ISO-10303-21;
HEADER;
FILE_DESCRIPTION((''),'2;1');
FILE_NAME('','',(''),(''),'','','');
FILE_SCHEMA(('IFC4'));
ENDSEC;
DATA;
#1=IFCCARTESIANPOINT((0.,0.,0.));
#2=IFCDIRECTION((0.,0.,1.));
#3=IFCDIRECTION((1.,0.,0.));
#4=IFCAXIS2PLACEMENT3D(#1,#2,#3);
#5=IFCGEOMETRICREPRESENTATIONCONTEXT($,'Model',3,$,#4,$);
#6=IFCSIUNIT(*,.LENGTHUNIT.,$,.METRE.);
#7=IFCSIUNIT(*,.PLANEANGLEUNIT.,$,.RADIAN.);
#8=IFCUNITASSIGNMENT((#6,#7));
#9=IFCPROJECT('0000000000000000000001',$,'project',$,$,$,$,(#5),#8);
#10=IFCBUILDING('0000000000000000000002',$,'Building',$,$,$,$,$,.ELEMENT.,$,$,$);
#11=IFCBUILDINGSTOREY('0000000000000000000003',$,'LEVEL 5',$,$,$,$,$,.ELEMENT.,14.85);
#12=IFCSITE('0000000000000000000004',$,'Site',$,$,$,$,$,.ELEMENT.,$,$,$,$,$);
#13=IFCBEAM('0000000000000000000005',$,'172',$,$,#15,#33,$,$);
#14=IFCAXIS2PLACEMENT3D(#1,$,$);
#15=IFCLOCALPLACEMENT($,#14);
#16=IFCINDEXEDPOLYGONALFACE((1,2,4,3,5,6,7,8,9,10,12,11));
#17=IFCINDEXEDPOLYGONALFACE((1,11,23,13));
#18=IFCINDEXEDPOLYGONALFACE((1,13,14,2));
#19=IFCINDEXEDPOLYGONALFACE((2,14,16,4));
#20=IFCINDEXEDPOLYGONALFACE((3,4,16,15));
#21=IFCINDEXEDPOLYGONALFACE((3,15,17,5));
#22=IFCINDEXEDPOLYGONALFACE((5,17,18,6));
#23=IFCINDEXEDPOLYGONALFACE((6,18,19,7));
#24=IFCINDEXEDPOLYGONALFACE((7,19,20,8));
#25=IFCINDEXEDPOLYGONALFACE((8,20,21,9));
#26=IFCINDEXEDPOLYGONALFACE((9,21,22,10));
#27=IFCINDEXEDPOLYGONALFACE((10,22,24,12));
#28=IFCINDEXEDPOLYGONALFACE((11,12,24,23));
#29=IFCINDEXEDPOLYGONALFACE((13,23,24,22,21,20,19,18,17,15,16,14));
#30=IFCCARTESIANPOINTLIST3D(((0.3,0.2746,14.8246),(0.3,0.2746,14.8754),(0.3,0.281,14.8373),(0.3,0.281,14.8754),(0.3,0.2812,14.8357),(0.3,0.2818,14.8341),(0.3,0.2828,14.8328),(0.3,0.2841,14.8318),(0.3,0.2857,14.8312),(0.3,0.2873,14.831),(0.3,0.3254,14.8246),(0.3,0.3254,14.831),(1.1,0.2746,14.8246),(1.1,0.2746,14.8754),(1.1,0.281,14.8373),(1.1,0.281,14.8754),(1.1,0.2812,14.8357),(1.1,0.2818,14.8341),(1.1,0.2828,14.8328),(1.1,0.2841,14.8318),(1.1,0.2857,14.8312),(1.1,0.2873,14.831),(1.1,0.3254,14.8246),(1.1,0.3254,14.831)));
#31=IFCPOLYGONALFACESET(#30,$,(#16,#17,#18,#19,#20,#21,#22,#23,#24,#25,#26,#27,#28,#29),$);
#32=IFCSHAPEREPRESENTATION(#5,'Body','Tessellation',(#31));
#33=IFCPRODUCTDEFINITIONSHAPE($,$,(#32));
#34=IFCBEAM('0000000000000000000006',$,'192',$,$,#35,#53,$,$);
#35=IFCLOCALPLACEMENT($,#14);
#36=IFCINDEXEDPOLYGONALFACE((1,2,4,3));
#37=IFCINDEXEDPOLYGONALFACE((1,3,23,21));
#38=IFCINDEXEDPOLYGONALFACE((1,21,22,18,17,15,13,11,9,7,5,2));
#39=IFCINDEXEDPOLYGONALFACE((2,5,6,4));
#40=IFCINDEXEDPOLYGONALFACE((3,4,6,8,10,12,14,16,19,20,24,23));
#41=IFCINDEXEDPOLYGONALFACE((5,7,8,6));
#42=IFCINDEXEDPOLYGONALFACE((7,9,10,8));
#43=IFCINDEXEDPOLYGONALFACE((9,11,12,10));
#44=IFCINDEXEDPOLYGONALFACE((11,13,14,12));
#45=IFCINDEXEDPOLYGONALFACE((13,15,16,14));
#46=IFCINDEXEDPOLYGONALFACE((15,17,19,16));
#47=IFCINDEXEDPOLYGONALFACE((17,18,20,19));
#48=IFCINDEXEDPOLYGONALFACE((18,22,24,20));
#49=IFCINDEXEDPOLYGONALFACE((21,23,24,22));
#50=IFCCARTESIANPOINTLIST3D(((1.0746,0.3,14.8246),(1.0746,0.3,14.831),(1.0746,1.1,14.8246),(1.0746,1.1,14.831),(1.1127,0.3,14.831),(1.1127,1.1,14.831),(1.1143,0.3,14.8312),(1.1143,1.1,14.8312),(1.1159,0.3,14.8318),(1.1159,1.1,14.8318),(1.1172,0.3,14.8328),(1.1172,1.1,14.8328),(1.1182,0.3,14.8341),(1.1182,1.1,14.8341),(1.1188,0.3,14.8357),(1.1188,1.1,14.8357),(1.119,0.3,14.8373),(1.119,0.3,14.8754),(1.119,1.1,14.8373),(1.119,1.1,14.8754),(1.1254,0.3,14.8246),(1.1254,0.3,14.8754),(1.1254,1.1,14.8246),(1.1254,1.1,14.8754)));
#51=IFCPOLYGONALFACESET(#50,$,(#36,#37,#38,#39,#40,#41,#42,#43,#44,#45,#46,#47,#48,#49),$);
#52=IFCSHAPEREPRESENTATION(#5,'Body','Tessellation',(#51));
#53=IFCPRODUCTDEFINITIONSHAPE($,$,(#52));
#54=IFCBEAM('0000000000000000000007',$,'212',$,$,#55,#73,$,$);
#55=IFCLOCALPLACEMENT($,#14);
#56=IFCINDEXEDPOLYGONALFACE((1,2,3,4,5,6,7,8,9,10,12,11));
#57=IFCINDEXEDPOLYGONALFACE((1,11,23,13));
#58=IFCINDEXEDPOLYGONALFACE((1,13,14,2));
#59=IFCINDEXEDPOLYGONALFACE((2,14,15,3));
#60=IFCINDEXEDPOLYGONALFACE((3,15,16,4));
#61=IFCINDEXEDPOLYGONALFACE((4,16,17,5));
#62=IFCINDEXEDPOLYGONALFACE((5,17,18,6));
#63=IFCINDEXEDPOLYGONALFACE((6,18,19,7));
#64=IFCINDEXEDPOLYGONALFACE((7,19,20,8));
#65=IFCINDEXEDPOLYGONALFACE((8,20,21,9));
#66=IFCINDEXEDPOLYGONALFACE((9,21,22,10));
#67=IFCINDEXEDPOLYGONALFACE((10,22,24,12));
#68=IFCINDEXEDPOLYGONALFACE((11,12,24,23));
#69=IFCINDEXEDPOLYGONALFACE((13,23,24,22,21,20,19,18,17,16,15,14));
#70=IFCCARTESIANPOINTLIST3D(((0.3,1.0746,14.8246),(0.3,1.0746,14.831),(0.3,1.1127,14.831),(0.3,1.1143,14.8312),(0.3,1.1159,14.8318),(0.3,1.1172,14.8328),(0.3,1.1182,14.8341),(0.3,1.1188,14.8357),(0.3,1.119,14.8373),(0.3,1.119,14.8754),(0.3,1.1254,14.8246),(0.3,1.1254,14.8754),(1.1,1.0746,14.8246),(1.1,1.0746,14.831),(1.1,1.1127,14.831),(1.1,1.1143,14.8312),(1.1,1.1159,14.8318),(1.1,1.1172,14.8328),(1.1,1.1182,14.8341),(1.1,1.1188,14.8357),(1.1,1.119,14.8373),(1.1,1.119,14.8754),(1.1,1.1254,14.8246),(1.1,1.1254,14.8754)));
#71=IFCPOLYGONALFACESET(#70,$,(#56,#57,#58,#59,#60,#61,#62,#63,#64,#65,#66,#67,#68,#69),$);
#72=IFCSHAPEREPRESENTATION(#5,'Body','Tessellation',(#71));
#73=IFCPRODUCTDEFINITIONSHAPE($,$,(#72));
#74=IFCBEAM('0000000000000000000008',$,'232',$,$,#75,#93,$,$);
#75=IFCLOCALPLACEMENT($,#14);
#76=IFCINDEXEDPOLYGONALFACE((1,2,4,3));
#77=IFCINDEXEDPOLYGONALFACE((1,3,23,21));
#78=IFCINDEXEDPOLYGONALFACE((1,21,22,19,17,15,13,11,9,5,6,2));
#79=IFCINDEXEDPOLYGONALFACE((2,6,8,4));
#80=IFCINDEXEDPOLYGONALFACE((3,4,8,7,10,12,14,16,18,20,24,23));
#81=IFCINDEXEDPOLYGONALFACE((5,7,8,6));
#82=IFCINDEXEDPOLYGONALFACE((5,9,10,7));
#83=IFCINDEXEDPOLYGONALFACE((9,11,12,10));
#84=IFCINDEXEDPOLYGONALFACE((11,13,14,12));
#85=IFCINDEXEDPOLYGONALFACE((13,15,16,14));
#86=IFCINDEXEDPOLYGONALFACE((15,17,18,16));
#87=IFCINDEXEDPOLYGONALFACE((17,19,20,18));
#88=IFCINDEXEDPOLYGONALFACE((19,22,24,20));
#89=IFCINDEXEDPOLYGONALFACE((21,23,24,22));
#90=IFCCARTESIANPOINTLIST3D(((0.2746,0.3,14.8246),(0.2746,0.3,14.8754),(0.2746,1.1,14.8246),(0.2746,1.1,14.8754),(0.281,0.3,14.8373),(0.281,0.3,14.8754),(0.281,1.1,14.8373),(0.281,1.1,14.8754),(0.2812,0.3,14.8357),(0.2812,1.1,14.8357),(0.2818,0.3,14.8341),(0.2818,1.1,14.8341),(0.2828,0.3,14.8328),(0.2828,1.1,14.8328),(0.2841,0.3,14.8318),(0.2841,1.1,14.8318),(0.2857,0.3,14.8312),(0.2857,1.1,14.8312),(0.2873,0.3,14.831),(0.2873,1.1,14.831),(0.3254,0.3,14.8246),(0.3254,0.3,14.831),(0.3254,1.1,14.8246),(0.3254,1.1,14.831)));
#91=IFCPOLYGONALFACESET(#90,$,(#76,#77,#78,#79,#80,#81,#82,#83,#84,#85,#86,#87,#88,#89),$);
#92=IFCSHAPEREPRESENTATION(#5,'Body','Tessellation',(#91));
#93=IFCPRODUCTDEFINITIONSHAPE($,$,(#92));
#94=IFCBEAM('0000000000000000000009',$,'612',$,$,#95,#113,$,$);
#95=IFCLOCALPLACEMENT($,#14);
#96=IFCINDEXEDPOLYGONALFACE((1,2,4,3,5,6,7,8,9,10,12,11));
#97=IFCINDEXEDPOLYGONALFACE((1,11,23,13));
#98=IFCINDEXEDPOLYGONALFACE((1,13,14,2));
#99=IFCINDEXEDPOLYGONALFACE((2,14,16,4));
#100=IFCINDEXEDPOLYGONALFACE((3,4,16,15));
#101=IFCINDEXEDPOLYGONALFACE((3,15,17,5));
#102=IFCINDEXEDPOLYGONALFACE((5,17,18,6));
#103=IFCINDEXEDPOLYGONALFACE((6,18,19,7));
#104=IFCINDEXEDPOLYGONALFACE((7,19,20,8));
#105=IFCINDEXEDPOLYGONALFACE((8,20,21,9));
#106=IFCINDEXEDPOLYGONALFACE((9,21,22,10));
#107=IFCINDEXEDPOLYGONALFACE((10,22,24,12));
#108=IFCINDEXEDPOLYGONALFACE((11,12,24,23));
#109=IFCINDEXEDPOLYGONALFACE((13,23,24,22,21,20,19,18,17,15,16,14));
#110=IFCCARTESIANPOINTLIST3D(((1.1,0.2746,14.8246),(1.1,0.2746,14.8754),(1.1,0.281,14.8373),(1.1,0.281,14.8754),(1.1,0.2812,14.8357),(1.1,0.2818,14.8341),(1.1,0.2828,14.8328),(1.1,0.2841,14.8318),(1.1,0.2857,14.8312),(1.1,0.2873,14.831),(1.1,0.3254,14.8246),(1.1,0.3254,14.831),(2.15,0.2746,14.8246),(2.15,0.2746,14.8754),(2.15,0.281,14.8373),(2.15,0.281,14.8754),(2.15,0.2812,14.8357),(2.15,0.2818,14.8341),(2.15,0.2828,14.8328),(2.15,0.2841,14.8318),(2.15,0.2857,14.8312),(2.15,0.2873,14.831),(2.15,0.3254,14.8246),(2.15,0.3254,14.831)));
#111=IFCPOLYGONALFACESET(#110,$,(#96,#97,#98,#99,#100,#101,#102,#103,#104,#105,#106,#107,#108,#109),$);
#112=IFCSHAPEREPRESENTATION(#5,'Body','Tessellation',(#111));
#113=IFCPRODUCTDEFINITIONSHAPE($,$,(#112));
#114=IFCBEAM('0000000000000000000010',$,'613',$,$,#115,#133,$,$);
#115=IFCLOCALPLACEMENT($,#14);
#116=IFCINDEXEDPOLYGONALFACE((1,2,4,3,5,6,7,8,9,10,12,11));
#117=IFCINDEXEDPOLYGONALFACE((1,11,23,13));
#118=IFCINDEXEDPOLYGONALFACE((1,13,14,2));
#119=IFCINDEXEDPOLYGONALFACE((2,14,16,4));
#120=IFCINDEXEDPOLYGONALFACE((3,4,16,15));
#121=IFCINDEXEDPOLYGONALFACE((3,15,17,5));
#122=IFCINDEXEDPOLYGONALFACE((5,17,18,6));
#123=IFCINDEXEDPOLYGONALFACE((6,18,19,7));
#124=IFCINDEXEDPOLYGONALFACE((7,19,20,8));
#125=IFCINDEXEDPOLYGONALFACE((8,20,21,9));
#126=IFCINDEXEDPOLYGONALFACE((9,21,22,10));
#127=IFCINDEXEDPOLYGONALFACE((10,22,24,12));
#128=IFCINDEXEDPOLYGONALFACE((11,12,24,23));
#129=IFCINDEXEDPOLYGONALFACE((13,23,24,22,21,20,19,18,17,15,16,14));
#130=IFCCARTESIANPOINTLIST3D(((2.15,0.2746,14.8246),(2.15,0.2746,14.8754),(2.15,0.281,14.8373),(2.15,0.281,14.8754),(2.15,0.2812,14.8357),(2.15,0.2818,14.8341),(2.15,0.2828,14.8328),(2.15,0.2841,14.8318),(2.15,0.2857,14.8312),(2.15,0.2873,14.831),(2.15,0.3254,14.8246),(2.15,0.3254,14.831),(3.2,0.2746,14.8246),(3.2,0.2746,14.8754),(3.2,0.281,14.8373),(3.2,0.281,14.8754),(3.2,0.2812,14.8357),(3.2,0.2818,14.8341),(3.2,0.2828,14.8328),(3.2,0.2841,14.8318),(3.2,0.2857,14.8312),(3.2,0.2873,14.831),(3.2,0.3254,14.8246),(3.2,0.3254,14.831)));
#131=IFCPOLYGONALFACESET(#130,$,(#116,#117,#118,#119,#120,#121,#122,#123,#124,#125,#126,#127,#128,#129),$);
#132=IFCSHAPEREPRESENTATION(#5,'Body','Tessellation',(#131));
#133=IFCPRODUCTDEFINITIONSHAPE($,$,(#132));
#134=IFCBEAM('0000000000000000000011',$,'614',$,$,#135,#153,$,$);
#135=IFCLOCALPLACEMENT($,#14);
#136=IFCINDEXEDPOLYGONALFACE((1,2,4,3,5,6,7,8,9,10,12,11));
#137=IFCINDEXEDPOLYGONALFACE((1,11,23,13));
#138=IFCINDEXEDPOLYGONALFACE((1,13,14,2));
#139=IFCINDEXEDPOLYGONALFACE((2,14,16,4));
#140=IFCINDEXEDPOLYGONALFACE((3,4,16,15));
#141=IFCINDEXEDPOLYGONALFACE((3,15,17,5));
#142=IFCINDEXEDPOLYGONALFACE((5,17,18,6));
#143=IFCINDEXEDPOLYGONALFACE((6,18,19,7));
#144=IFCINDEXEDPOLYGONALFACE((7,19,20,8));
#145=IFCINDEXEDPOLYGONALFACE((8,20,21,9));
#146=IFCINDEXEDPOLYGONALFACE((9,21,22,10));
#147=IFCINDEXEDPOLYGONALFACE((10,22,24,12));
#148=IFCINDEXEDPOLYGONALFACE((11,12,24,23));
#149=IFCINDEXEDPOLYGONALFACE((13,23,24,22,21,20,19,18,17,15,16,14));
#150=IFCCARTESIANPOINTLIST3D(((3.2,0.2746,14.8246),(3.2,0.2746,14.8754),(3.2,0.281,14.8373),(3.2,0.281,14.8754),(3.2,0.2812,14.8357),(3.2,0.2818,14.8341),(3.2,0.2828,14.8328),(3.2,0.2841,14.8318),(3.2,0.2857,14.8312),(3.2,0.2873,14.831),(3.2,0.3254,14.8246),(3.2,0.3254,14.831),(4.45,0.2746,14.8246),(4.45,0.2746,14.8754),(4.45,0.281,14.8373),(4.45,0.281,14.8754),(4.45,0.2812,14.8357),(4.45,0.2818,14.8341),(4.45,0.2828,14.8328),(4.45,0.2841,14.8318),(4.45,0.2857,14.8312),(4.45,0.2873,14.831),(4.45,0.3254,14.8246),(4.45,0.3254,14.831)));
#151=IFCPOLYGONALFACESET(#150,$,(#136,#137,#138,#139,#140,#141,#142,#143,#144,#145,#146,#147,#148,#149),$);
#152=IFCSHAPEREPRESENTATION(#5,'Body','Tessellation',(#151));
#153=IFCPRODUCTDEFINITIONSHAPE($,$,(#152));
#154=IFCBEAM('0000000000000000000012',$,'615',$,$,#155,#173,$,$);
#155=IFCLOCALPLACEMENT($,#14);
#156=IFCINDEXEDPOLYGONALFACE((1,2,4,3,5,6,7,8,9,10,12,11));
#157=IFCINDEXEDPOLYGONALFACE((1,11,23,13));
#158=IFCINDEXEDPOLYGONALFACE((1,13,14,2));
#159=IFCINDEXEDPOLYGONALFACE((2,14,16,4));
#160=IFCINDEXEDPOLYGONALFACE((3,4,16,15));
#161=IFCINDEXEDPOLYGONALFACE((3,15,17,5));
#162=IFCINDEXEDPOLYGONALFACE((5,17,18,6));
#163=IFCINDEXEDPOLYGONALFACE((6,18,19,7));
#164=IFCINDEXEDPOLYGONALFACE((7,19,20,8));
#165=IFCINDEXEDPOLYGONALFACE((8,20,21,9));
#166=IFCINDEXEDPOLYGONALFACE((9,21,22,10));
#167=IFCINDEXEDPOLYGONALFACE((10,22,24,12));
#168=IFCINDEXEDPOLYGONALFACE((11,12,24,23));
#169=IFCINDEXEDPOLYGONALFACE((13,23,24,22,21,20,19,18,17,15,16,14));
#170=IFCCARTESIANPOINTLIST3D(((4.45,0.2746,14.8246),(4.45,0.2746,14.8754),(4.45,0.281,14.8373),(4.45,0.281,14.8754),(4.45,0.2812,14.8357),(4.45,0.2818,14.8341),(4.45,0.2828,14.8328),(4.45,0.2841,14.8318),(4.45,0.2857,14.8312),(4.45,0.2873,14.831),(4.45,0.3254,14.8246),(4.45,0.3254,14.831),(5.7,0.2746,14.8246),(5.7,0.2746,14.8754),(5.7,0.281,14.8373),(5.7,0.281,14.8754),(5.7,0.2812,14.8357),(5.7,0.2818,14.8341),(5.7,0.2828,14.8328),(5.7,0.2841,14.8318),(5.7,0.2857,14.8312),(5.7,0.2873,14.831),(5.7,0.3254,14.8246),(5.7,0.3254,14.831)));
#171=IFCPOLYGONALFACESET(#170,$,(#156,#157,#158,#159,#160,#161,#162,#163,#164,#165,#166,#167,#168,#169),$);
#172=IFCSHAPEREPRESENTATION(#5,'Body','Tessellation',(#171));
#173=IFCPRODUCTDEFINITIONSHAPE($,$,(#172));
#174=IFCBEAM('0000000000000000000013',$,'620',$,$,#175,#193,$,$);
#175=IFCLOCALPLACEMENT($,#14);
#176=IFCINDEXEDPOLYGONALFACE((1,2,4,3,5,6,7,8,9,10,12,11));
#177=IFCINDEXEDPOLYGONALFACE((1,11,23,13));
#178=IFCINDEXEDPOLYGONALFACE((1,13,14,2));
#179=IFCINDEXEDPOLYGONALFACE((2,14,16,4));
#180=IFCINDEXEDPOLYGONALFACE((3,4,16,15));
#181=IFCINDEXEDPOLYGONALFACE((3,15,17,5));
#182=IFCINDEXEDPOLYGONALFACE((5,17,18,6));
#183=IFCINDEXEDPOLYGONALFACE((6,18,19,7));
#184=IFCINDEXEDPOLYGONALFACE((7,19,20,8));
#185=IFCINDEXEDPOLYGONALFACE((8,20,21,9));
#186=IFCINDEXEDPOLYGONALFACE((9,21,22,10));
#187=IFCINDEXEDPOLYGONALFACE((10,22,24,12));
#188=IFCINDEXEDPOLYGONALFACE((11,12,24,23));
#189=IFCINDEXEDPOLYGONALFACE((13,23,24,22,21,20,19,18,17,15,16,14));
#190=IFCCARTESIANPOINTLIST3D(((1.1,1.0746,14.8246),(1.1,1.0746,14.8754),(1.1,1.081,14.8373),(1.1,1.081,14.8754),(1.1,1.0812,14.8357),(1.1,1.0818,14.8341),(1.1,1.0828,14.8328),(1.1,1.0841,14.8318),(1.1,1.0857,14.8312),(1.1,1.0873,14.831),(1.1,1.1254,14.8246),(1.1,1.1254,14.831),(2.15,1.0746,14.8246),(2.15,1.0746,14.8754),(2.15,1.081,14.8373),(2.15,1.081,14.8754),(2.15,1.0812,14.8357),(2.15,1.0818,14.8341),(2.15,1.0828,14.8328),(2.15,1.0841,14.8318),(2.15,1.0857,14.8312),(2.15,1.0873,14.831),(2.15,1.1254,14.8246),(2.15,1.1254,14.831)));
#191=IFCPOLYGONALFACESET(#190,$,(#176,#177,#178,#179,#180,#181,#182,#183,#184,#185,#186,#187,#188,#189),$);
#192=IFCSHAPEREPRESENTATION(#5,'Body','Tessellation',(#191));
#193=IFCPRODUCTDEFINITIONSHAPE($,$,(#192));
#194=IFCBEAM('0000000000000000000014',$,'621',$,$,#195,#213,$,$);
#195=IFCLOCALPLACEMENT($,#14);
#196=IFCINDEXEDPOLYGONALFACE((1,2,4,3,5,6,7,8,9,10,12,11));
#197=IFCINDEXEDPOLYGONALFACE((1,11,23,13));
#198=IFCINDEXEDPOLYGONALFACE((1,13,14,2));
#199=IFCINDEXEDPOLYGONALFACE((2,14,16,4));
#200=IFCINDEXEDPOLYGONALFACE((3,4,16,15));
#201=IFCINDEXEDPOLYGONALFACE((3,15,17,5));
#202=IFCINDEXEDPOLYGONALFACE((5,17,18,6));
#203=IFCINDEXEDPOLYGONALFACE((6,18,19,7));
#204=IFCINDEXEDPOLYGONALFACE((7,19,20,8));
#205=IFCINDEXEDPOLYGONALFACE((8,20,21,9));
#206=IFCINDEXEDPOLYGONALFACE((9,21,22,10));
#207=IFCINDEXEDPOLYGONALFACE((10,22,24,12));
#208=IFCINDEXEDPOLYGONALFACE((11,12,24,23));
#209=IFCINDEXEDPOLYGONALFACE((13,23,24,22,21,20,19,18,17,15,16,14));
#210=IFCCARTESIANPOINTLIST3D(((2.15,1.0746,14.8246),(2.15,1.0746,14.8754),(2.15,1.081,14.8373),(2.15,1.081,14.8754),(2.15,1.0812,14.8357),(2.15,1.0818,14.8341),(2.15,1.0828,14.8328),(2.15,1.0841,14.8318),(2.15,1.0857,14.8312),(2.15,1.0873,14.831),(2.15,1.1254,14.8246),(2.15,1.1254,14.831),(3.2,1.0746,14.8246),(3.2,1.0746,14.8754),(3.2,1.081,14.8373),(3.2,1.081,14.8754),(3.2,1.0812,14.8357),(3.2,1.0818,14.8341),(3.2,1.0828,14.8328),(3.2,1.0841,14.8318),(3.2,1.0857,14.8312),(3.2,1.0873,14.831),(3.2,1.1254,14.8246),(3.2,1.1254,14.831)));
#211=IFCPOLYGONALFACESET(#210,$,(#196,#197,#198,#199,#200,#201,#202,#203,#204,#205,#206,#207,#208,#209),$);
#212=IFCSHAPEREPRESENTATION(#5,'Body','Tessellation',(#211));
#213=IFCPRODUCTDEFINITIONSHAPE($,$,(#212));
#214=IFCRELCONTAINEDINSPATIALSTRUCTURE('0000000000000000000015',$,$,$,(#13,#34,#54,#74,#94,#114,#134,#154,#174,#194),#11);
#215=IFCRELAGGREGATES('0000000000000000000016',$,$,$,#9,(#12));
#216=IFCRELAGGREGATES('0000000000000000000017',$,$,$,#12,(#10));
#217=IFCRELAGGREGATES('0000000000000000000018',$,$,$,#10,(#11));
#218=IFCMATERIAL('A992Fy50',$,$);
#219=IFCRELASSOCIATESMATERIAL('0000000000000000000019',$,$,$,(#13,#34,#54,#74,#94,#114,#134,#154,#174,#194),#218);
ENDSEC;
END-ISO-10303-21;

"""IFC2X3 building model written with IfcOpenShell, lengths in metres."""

from ifc_helpers import new_model, si_unit, frame, origin_with_axes, origin_2d_with_axis, place, context, project, spatial, l_section, extrude, material, element, save


model = new_model("IFC2X3")

# Units and contexts
model_context = context("Model", 3, world=origin_with_axes())
ifc_project = project(units=[si_unit("LENGTHUNIT", "METRE"), si_unit("PLANEANGLEUNIT", "RADIAN")], contexts=[model_context])

# Site, building, storey
site = spatial("IfcSite", under=ifc_project, Name="Site", CompositionType="ELEMENT")
building = spatial("IfcBuilding", under=site, Name="Building", CompositionType="ELEMENT")
storey = spatial("IfcBuildingStorey", under=building, Name="LEVEL 5", CompositionType="ELEMENT", Elevation=14.85)

# Beams
ifc_material = material(Name="A992Fy50")
for number, where, z_axis, x_axis, name in (
    (1, (0.3, 0.3, 14.85), (1.0, 0.0, 0.0), (0.0, 1.0, 0.0), "172"),
    (2, (1.1, 0.3, 14.85), (0.0, 1.0, 0.0), (-1.0, 0.0, 0.0), "192"),
    (3, (1.1, 1.1, 14.85), (-1.0, 0.0, 0.0), (0.0, -1.0, 0.0), "212"),
    (4, (0.3, 1.1, 14.85), (0.0, -1.0, 0.0), (1.0, 0.0, 0.0), "232"),
):
    element("IfcBeam", number, at=place(None, frame(where, z_axis=z_axis, x_axis=x_axis)), inside=storey, material=ifc_material, Name=name, context=model_context, shape_type="SweptSolid", body=[
        extrude(l_section(Depth=0.0508, Width=0.0508, Thickness=0.0063, FilletRadius=0.0063, at=origin_2d_with_axis()), origin_with_axes(), (0.0, 0.0, 1.0), 0.8),
    ])
for number, where, z_axis, x_axis, name in (
    (5, (1.1, 0.3, 14.85), (1.0, 0.0, 0.0), (0.0, 1.0, 0.0), "612"),
    (6, (2.15, 0.3, 14.85), (1.0, 0.0, 0.0), (0.0, 1.0, 0.0), "613"),
):
    element("IfcBeam", number, at=place(None, frame(where, z_axis=z_axis, x_axis=x_axis)), inside=storey, material=ifc_material, Name=name, context=model_context, shape_type="SweptSolid", body=[
        extrude(l_section(Depth=0.0508, Width=0.0508, Thickness=0.0063, FilletRadius=0.0063, at=origin_2d_with_axis()), origin_with_axes(), (0.0, 0.0, 1.0), 1.05),
    ])
for number, where, z_axis, x_axis, name in (
    (7, (3.2, 0.3, 14.85), (1.0, 0.0, 0.0), (0.0, 1.0, 0.0), "614"),
    (8, (4.45, 0.3, 14.85), (1.0, 0.0, 0.0), (0.0, 1.0, 0.0), "615"),
):
    element("IfcBeam", number, at=place(None, frame(where, z_axis=z_axis, x_axis=x_axis)), inside=storey, material=ifc_material, Name=name, context=model_context, shape_type="SweptSolid", body=[
        extrude(l_section(Depth=0.0508, Width=0.0508, Thickness=0.0063, FilletRadius=0.0063, at=origin_2d_with_axis()), origin_with_axes(), (0.0, 0.0, 1.0), 1.25),
    ])
for number, where, z_axis, x_axis, name in (
    (9, (1.1, 1.1, 14.85), (1.0, 0.0, 0.0), (0.0, 1.0, 0.0), "620"),
    (10, (2.15, 1.1, 14.85), (1.0, 0.0, 0.0), (0.0, 1.0, 0.0), "621"),
):
    element("IfcBeam", number, at=place(None, frame(where, z_axis=z_axis, x_axis=x_axis)), inside=storey, material=ifc_material, Name=name, context=model_context, shape_type="SweptSolid", body=[
        extrude(l_section(Depth=0.0508, Width=0.0508, Thickness=0.0063, FilletRadius=0.0063, at=origin_2d_with_axis()), origin_with_axes(), (0.0, 0.0, 1.0), 1.05),
    ])

save(model, "model.ifc")
